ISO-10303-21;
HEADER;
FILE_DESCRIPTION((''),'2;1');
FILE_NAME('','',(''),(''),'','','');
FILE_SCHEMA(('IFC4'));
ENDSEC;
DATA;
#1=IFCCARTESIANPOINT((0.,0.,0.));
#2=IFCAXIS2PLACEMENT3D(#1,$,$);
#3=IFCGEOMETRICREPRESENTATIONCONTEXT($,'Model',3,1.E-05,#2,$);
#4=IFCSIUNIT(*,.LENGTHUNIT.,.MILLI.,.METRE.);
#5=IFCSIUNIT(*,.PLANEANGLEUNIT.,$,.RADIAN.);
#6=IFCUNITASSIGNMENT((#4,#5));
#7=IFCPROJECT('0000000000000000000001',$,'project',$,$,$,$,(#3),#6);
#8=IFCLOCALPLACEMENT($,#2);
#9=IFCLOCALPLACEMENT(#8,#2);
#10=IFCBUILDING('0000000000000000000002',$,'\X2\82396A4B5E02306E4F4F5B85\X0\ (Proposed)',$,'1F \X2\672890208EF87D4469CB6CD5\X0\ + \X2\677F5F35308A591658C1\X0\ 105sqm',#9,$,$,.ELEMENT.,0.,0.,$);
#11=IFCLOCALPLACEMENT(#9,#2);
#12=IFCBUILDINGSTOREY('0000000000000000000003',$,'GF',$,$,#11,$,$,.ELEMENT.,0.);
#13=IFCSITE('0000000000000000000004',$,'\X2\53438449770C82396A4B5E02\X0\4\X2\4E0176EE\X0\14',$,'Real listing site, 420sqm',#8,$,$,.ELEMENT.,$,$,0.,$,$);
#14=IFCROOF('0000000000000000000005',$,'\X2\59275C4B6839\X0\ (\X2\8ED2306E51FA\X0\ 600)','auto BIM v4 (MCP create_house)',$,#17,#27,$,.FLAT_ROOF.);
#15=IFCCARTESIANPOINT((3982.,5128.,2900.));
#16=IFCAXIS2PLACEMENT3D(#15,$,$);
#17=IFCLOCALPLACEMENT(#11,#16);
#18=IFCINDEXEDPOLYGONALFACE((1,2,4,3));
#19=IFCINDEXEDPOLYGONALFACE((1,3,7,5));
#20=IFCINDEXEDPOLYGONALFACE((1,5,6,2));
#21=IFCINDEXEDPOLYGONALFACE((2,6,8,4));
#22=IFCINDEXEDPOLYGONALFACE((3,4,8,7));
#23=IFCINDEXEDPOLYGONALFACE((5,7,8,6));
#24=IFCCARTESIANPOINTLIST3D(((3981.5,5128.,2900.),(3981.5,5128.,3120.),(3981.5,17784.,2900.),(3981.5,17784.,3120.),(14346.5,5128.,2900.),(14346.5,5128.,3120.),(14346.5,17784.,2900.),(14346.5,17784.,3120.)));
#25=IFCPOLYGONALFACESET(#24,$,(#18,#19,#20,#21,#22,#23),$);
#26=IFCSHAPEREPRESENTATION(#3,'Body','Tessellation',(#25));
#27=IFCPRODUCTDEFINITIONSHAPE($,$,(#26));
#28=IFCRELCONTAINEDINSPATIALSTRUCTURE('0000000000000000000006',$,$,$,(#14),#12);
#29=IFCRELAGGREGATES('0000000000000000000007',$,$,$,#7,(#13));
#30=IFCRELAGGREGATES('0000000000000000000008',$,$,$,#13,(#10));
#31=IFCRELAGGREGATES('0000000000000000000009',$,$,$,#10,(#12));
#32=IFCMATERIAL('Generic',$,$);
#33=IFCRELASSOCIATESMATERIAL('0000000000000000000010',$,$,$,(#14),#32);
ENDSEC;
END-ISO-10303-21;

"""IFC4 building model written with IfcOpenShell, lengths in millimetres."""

from ifc_helpers import new_model, si_unit, frame, frame_2d, origin, place, context, project, spatial, rectangle, extrude, material, element, save


model = new_model("IFC4")

# Units and contexts
model_context = context("Model", 3, precision=1e-05, world=origin())
ifc_project = project(units=[si_unit("LENGTHUNIT", "METRE", prefix="MILLI"), si_unit("PLANEANGLEUNIT", "RADIAN")], contexts=[model_context])

# Site, building, storey
site_placement = place(None, origin())
site = spatial("IfcSite", under=ifc_project, at=site_placement, Name="千葉県船橋市4丁目14", ObjectType="Real listing site, 420sqm", CompositionType="ELEMENT", RefElevation=0.0)
building_placement = place(site_placement, origin())
building = spatial("IfcBuilding", under=site, at=building_placement, Name="船橋市の住宅 (Proposed)", ObjectType="1F 木造軸組構法 + 板張り外壁 105sqm", CompositionType="ELEMENT", ElevationOfRefHeight=0.0, ElevationOfTerrain=0.0)
storey_placement = place(building_placement, origin())
storey = spatial("IfcBuildingStorey", under=building, at=storey_placement, Name="GF", CompositionType="ELEMENT", Elevation=0.0)

# Shared definitions
ifc_material = material(Name="Generic")

# Roof
roof_placement = place(storey_placement, frame((3982.0, 5128.0, 2900.0)))
element("IfcRoof", 1, at=roof_placement, inside=storey, material=ifc_material, Name="大屋根 (軒の出 600)", Description="auto BIM v4 (MCP create_house)", PredefinedType="FLAT_ROOF", context=model_context, shape_type="SweptSolid", body=[
    extrude(rectangle(XDim=10365.0, YDim=12656.0, at=frame_2d((5182.0, 6328.0))), frame((3982.0, 5128.0, 2900.0)), (0.0, 0.0, 1.0), 220.0),
])

save(model, "model.ifc")
